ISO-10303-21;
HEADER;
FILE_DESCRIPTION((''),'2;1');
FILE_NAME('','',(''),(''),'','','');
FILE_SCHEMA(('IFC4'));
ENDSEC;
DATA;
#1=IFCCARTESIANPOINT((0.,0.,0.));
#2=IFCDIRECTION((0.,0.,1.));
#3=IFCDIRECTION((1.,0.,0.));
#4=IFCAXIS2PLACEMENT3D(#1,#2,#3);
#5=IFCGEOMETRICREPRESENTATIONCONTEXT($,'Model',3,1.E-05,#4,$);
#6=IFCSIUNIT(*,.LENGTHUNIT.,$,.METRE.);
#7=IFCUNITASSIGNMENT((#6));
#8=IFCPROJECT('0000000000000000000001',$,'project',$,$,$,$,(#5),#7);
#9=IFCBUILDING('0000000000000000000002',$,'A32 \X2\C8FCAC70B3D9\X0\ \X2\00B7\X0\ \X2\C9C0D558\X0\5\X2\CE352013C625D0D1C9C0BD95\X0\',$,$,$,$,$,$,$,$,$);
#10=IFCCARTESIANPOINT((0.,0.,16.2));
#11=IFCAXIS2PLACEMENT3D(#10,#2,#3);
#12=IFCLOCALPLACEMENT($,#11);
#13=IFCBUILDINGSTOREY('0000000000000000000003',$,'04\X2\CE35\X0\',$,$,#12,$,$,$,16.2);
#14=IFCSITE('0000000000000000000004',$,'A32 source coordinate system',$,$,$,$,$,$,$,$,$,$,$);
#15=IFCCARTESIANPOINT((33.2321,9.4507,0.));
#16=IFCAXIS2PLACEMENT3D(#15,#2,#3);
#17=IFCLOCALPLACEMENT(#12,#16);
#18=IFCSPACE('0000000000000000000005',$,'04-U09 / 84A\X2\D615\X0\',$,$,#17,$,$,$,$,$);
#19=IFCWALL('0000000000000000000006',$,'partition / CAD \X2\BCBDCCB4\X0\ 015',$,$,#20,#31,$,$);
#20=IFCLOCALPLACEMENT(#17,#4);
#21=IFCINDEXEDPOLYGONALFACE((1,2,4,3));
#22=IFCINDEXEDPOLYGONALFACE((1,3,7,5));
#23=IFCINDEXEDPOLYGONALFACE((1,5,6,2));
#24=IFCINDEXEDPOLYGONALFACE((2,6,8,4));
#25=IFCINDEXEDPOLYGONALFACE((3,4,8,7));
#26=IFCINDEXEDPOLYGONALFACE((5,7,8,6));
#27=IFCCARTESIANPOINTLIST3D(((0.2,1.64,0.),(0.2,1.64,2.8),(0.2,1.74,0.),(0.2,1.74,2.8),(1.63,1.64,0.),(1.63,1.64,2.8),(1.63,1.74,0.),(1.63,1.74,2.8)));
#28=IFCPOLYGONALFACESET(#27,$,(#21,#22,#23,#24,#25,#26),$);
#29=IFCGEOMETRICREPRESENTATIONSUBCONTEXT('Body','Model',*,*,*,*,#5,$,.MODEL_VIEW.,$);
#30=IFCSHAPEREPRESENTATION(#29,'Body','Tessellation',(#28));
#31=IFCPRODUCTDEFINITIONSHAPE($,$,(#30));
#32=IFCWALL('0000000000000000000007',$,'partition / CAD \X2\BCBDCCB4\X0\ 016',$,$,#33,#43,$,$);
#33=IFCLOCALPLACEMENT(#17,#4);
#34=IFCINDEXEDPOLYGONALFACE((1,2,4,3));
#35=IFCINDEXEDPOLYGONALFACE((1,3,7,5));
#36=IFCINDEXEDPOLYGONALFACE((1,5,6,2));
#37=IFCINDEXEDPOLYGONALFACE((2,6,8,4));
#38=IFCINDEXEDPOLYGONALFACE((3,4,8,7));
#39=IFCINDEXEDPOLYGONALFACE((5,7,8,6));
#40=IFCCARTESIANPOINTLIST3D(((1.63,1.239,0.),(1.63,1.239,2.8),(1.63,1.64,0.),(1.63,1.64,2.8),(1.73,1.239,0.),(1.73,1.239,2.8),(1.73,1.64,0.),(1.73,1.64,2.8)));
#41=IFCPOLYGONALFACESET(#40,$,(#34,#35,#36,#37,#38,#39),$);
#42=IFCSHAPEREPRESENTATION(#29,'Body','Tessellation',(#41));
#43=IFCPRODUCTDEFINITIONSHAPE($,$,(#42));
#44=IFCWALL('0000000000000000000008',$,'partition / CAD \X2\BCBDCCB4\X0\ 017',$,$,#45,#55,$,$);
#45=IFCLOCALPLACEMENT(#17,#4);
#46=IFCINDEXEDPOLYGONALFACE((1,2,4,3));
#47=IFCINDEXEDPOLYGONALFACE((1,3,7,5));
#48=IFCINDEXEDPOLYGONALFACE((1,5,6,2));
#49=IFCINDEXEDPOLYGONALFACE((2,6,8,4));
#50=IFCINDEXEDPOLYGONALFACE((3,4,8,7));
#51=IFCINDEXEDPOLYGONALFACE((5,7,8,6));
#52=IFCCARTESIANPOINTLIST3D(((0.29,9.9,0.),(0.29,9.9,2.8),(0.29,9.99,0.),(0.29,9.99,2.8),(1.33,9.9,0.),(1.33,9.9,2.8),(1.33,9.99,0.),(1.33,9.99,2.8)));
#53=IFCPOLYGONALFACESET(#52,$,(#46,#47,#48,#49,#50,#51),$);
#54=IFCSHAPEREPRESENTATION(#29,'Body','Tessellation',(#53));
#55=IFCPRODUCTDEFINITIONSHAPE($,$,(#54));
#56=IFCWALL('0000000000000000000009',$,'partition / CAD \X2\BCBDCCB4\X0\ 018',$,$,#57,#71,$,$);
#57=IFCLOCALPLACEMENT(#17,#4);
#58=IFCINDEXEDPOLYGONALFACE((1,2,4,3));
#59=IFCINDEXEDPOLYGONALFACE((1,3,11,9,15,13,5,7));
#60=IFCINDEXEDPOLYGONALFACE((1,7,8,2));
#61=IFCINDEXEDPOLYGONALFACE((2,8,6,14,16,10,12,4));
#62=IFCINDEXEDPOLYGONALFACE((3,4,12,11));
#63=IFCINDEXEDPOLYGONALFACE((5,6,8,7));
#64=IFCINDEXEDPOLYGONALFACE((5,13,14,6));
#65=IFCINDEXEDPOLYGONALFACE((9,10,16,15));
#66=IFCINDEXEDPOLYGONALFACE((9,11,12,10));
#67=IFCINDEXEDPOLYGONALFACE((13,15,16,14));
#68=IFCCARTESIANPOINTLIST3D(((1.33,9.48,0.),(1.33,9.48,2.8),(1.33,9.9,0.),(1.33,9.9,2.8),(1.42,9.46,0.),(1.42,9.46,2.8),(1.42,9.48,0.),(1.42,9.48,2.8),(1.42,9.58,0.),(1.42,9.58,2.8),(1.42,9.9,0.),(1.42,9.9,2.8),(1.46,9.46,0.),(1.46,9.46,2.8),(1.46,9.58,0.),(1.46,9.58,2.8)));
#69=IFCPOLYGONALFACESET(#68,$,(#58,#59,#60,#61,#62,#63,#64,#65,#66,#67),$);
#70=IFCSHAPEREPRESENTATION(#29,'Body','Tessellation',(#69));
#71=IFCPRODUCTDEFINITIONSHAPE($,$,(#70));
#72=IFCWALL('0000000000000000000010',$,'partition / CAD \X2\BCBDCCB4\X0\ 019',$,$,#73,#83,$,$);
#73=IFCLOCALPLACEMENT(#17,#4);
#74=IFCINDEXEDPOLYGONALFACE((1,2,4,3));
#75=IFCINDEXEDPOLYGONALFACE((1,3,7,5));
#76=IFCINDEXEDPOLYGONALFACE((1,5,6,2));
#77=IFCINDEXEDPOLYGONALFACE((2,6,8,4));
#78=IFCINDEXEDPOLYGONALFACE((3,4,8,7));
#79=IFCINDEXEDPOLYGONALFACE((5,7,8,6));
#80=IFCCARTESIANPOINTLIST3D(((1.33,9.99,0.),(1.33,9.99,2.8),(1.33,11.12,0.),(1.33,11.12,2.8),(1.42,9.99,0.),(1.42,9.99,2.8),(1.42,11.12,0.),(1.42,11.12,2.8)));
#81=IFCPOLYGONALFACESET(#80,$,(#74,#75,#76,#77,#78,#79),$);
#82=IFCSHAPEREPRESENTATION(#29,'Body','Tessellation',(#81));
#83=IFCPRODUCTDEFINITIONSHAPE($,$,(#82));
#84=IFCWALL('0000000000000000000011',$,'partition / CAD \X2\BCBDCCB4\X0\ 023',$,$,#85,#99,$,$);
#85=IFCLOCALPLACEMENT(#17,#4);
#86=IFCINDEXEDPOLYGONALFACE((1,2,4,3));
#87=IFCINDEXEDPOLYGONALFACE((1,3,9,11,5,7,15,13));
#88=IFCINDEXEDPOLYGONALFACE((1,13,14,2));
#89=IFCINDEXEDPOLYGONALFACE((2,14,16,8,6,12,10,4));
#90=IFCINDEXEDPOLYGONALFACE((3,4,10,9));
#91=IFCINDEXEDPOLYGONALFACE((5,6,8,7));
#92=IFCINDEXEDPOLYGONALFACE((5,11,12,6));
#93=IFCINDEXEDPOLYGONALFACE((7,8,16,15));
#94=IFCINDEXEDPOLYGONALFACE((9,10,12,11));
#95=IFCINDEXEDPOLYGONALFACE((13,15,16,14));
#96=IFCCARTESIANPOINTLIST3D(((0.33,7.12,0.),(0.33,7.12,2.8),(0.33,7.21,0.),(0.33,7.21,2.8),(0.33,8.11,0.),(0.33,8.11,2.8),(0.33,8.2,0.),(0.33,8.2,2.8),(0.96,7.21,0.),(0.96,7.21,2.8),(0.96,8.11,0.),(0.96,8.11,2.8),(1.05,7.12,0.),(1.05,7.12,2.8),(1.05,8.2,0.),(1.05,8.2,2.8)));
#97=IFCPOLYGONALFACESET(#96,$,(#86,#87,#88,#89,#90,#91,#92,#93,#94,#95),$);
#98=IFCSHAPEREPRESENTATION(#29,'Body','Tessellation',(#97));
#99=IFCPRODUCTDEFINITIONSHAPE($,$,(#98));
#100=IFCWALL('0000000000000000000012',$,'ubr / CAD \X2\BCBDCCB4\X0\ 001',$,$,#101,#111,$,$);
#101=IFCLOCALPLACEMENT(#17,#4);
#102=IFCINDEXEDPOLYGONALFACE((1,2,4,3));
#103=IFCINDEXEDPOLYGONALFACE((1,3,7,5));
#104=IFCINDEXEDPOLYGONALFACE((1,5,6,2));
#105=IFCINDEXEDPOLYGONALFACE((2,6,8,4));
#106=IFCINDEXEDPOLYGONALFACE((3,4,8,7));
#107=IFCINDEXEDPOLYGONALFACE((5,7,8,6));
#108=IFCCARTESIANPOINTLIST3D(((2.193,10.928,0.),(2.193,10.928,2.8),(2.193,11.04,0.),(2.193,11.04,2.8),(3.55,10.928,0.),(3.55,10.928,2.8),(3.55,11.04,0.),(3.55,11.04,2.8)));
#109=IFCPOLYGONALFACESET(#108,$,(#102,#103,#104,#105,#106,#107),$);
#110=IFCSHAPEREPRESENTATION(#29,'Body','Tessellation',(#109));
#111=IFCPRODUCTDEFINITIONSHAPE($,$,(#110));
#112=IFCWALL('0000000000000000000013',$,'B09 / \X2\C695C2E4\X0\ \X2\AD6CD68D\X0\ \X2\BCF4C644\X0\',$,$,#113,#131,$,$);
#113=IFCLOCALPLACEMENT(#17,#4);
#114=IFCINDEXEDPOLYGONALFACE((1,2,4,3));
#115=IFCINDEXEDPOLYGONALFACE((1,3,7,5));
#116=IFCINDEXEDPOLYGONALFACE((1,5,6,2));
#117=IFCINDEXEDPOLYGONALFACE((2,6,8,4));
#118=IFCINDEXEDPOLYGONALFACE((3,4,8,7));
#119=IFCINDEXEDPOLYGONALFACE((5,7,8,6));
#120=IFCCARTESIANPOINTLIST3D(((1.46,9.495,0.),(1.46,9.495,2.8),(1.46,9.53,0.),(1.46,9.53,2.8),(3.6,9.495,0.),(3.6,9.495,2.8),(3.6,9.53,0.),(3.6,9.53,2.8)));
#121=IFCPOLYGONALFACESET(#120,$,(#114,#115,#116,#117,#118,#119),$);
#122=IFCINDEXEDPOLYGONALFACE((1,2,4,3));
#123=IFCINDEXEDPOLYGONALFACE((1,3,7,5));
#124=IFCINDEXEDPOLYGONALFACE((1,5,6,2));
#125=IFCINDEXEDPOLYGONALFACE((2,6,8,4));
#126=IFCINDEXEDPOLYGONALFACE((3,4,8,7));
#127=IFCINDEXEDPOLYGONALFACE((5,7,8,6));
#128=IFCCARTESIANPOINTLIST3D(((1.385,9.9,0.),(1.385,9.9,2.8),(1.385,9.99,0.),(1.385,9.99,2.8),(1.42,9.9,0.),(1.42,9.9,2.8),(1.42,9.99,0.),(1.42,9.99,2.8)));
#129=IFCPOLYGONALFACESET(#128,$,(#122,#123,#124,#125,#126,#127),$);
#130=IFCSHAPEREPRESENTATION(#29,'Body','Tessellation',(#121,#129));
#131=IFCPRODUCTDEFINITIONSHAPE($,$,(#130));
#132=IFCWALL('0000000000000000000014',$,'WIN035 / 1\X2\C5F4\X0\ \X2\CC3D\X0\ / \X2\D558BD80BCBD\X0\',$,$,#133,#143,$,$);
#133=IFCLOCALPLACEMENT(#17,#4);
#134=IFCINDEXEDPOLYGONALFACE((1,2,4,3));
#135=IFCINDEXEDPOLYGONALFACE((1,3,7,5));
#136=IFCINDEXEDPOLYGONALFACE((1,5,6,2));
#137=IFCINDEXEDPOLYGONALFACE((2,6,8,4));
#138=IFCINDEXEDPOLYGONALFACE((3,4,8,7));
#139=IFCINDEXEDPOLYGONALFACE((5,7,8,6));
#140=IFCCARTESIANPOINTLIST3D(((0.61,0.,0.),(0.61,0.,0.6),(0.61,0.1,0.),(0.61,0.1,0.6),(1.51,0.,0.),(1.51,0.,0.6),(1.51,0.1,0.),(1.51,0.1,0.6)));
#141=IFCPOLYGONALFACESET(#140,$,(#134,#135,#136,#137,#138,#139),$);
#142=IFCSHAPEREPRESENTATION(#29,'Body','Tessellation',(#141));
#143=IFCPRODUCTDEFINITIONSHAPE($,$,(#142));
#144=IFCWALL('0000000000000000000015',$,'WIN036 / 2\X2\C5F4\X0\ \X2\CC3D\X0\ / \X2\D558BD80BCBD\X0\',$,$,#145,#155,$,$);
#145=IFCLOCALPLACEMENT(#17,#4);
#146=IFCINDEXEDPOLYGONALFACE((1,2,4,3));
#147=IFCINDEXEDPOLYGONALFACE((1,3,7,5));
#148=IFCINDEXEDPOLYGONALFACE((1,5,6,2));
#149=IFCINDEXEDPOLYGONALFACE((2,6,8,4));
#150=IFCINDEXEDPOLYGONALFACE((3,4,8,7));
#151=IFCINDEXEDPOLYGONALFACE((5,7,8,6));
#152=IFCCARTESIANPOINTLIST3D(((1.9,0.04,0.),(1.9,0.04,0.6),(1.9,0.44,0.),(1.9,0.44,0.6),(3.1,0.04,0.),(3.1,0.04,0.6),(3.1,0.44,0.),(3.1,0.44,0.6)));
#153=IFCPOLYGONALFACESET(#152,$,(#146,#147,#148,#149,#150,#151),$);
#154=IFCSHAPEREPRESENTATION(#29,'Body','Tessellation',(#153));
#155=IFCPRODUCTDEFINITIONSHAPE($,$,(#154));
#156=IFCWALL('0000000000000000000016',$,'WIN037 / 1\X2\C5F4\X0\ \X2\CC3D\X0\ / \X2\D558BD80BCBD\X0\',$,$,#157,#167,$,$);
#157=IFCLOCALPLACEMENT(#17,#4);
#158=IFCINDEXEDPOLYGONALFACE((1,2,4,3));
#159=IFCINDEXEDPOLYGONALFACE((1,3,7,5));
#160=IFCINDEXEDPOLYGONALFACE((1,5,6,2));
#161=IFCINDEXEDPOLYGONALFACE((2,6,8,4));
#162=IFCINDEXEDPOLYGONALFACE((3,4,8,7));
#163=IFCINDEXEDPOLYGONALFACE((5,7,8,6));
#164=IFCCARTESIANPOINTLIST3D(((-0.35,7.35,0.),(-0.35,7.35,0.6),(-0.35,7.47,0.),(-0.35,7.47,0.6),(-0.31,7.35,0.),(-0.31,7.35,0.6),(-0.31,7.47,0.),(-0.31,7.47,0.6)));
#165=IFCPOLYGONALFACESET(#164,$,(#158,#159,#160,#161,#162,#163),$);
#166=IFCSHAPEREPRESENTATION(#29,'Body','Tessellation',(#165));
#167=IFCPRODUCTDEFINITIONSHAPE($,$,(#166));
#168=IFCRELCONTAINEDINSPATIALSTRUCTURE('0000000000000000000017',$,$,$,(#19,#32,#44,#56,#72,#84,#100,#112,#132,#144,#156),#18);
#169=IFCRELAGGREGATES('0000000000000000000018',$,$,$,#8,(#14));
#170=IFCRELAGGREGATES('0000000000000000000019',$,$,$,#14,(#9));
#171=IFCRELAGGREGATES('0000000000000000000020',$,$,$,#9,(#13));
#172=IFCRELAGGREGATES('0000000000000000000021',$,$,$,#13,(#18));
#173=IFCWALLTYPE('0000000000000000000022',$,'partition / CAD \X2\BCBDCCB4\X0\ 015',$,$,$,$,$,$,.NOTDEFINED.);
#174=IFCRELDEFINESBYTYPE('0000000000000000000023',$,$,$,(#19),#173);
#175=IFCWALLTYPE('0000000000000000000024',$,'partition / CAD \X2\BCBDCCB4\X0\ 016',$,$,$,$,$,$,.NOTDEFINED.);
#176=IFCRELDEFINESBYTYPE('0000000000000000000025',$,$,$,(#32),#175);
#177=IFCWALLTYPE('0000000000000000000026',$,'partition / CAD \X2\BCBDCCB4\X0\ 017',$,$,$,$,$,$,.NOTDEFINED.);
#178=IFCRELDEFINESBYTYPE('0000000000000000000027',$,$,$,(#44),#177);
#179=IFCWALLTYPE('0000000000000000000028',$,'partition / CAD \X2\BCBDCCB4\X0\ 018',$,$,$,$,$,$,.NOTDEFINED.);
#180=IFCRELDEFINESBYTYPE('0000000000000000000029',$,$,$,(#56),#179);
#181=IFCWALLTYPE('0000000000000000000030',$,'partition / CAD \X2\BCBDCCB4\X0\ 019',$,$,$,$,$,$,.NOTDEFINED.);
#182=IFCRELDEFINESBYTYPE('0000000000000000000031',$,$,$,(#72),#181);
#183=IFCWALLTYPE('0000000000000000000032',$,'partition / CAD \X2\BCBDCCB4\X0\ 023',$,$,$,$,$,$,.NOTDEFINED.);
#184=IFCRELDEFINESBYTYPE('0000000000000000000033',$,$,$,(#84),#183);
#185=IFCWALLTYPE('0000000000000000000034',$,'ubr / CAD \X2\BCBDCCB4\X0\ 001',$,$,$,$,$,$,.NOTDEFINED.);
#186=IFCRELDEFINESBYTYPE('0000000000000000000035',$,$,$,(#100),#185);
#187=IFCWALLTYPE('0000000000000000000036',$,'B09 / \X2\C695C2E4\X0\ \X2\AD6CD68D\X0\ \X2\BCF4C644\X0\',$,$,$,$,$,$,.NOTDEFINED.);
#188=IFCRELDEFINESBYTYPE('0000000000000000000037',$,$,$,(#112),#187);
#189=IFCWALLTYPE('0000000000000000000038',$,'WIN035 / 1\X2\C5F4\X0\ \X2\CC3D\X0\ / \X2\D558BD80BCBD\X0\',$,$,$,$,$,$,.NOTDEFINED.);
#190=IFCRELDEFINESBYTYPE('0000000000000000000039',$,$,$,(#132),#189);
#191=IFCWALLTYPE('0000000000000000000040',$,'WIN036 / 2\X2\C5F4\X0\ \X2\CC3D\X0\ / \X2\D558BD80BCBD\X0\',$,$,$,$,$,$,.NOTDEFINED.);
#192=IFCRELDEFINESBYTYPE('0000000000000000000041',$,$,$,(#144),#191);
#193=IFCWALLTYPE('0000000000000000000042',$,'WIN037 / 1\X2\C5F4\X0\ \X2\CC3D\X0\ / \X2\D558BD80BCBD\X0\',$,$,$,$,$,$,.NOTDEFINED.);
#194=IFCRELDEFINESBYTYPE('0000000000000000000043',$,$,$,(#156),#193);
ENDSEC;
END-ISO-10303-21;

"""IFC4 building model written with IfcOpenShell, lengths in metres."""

from ifc_helpers import new_model, si_unit, frame, origin, origin_with_axes, place, context, subcontext, project, spatial, polyline, outline, extrude, source, transform, mapped, type_object, type_shapes, element, save


model = new_model("IFC4")

# Units and contexts
model_context = context("Model", 3, precision=1e-05, world=origin_with_axes())
body_context = subcontext(model_context, "Body", "Model", "MODEL_VIEW")
ifc_project = project(units=[si_unit("LENGTHUNIT", "METRE")], contexts=[model_context])

# Site, building, storey, space
site = spatial("IfcSite", under=ifc_project, Name="A32 source coordinate system")
building = spatial("IfcBuilding", under=site, Name="A32 주거동 · 지하5층–옥탑지붕")
storey_placement = place(None, frame((0.0, 0.0, 16.2), z_axis=(0.0, 0.0, 1.0), x_axis=(1.0, 0.0, 0.0)))
storey = spatial("IfcBuildingStorey", under=building, at=storey_placement, Name="04층", Elevation=16.2)
space_1_placement = place(storey_placement, frame((33.2321, 9.4507, 0.0), z_axis=(0.0, 0.0, 1.0), x_axis=(1.0, 0.0, 0.0)))
space_1 = spatial("IfcSpace", under=storey, at=space_1_placement, Name="04-U09 / 84A형")

# Walls
wall_type_1 = type_object("IfcWallType", Name="partition / CAD 벽체 015", PredefinedType="NOTDEFINED")
shared_shape_1 = source(origin(), body_context, "Body", "SweptSolid", [
    extrude(outline(polyline([(1.63, 1.74), (1.63, 1.64), (0.2, 1.64), (0.2, 1.74), (1.63, 1.74)])), origin(), (0.0, 0.0, 1.0), 2.8),
])
type_shapes(wall_type_1, [shared_shape_1])
wall_1_placement = place(space_1_placement, origin_with_axes())
element("IfcWall", 1, at=wall_1_placement, inside=space_1, type_object=wall_type_1, Name="partition / CAD 벽체 015", context=body_context, shape_type="MappedRepresentation", body=[
    mapped(shared_shape_1, transform((0.0, 0.0, 0.0), scale=1.0)),
])
wall_type_2 = type_object("IfcWallType", Name="partition / CAD 벽체 016", PredefinedType="NOTDEFINED")
shared_shape_2 = source(origin(), body_context, "Body", "SweptSolid", [
    extrude(outline(polyline([(1.73, 1.239), (1.63, 1.239), (1.63, 1.64), (1.73, 1.64), (1.73, 1.239)])), origin(), (0.0, 0.0, 1.0), 2.8),
])
type_shapes(wall_type_2, [shared_shape_2])
wall_2_placement = place(space_1_placement, origin_with_axes())
element("IfcWall", 2, at=wall_2_placement, inside=space_1, type_object=wall_type_2, Name="partition / CAD 벽체 016", context=body_context, shape_type="MappedRepresentation", body=[
    mapped(shared_shape_2, transform((0.0, 0.0, 0.0), scale=1.0)),
])
wall_type_3 = type_object("IfcWallType", Name="partition / CAD 벽체 017", PredefinedType="NOTDEFINED")
shared_shape_3 = source(origin(), body_context, "Body", "SweptSolid", [
    extrude(outline(polyline([(1.33, 9.99), (1.33, 9.9), (0.29, 9.9), (0.29, 9.99), (1.33, 9.99)])), origin(), (0.0, 0.0, 1.0), 2.8),
])
type_shapes(wall_type_3, [shared_shape_3])
wall_3_placement = place(space_1_placement, origin_with_axes())
element("IfcWall", 3, at=wall_3_placement, inside=space_1, type_object=wall_type_3, Name="partition / CAD 벽체 017", context=body_context, shape_type="MappedRepresentation", body=[
    mapped(shared_shape_3, transform((0.0, 0.0, 0.0), scale=1.0)),
])
wall_type_4 = type_object("IfcWallType", Name="partition / CAD 벽체 018", PredefinedType="NOTDEFINED")
shared_shape_4 = source(origin(), body_context, "Body", "SweptSolid", [
    extrude(outline(polyline([(1.42, 9.58), (1.46, 9.58), (1.46, 9.46), (1.42, 9.46), (1.42, 9.48), (1.33, 9.48), (1.33, 9.9), (1.42, 9.9), (1.42, 9.58)])), origin(), (0.0, 0.0, 1.0), 2.8),
])
type_shapes(wall_type_4, [shared_shape_4])
wall_4_placement = place(space_1_placement, origin_with_axes())
element("IfcWall", 4, at=wall_4_placement, inside=space_1, type_object=wall_type_4, Name="partition / CAD 벽체 018", context=body_context, shape_type="MappedRepresentation", body=[
    mapped(shared_shape_4, transform((0.0, 0.0, 0.0), scale=1.0)),
])
wall_type_5 = type_object("IfcWallType", Name="partition / CAD 벽체 019", PredefinedType="NOTDEFINED")
shared_shape_5 = source(origin(), body_context, "Body", "SweptSolid", [
    extrude(outline(polyline([(1.33, 11.12), (1.42, 11.12), (1.42, 9.99), (1.33, 9.99), (1.33, 11.12)])), origin(), (0.0, 0.0, 1.0), 2.8),
])
type_shapes(wall_type_5, [shared_shape_5])
wall_5_placement = place(space_1_placement, origin_with_axes())
element("IfcWall", 5, at=wall_5_placement, inside=space_1, type_object=wall_type_5, Name="partition / CAD 벽체 019", context=body_context, shape_type="MappedRepresentation", body=[
    mapped(shared_shape_5, transform((0.0, 0.0, 0.0), scale=1.0)),
])
wall_type_6 = type_object("IfcWallType", Name="partition / CAD 벽체 023", PredefinedType="NOTDEFINED")
shared_shape_6 = source(origin(), body_context, "Body", "SweptSolid", [
    extrude(outline(polyline([(0.96, 8.11), (0.33, 8.11), (0.33, 8.2), (1.05, 8.2), (1.05, 7.12), (0.33, 7.12), (0.33, 7.21), (0.96, 7.21), (0.96, 8.11)])), origin(), (0.0, 0.0, 1.0), 2.8),
])
type_shapes(wall_type_6, [shared_shape_6])
wall_6_placement = place(space_1_placement, origin_with_axes())
element("IfcWall", 6, at=wall_6_placement, inside=space_1, type_object=wall_type_6, Name="partition / CAD 벽체 023", context=body_context, shape_type="MappedRepresentation", body=[
    mapped(shared_shape_6, transform((0.0, 0.0, 0.0), scale=1.0)),
])
wall_type_7 = type_object("IfcWallType", Name="ubr / CAD 벽체 001", PredefinedType="NOTDEFINED")
shared_shape_7 = source(origin(), body_context, "Body", "SweptSolid", [
    extrude(outline(polyline([(3.55, 11.04), (3.55, 10.928), (2.193, 10.928), (2.193, 11.04), (3.55, 11.04)])), origin(), (0.0, 0.0, 1.0), 2.8),
])
type_shapes(wall_type_7, [shared_shape_7])
wall_7_placement = place(space_1_placement, origin_with_axes())
element("IfcWall", 7, at=wall_7_placement, inside=space_1, type_object=wall_type_7, Name="ubr / CAD 벽체 001", context=body_context, shape_type="MappedRepresentation", body=[
    mapped(shared_shape_7, transform((0.0, 0.0, 0.0), scale=1.0)),
])
wall_type_8 = type_object("IfcWallType", Name="B09 / 욕실 구획 보완", PredefinedType="NOTDEFINED")
shared_shape_8 = source(origin(), body_context, "Body", "SweptSolid", [
    extrude(outline(polyline([(3.6, 9.53), (3.6, 9.495), (1.46, 9.495), (1.46, 9.53), (3.6, 9.53)])), origin(), (0.0, 0.0, 1.0), 2.8),
    extrude(outline(polyline([(1.42, 9.9), (1.385, 9.9), (1.385, 9.99), (1.42, 9.99), (1.42, 9.9)])), origin(), (0.0, 0.0, 1.0), 2.8),
])
type_shapes(wall_type_8, [shared_shape_8])
wall_8_placement = place(space_1_placement, origin_with_axes())
element("IfcWall", 8, at=wall_8_placement, inside=space_1, type_object=wall_type_8, Name="B09 / 욕실 구획 보완", context=body_context, shape_type="MappedRepresentation", body=[
    mapped(shared_shape_8, transform((0.0, 0.0, 0.0), scale=1.0)),
])
wall_type_9 = type_object("IfcWallType", Name="WIN035 / 1열 창 / 하부벽", PredefinedType="NOTDEFINED")
shared_shape_9 = source(origin(), body_context, "Body", "SweptSolid", [
    extrude(outline(polyline([(0.61, 0.1), (1.51, 0.1), (1.51, 0.0), (0.61, 0.0), (0.61, 0.1)])), origin(), (0.0, 0.0, 1.0), 0.6),
])
type_shapes(wall_type_9, [shared_shape_9])
wall_9_placement = place(space_1_placement, origin_with_axes())
element("IfcWall", 9, at=wall_9_placement, inside=space_1, type_object=wall_type_9, Name="WIN035 / 1열 창 / 하부벽", context=body_context, shape_type="MappedRepresentation", body=[
    mapped(shared_shape_9, transform((0.0, 0.0, 0.0), scale=1.0)),
])
wall_type_10 = type_object("IfcWallType", Name="WIN036 / 2열 창 / 하부벽", PredefinedType="NOTDEFINED")
shared_shape_10 = source(origin(), body_context, "Body", "SweptSolid", [
    extrude(outline(polyline([(1.9, 0.44), (3.1, 0.44), (3.1, 0.04), (1.9, 0.04), (1.9, 0.44)])), origin(), (0.0, 0.0, 1.0), 0.6),
])
type_shapes(wall_type_10, [shared_shape_10])
wall_10_placement = place(space_1_placement, origin_with_axes())
element("IfcWall", 10, at=wall_10_placement, inside=space_1, type_object=wall_type_10, Name="WIN036 / 2열 창 / 하부벽", context=body_context, shape_type="MappedRepresentation", body=[
    mapped(shared_shape_10, transform((0.0, 0.0, 0.0), scale=1.0)),
])
wall_type_11 = type_object("IfcWallType", Name="WIN037 / 1열 창 / 하부벽", PredefinedType="NOTDEFINED")
shared_shape_11 = source(origin(), body_context, "Body", "SweptSolid", [
    extrude(outline(polyline([(-0.31, 7.47), (-0.31, 7.35), (-0.35, 7.35), (-0.35, 7.47), (-0.31, 7.47)])), origin(), (0.0, 0.0, 1.0), 0.6),
])
type_shapes(wall_type_11, [shared_shape_11])
wall_11_placement = place(space_1_placement, origin_with_axes())
element("IfcWall", 11, at=wall_11_placement, inside=space_1, type_object=wall_type_11, Name="WIN037 / 1열 창 / 하부벽", context=body_context, shape_type="MappedRepresentation", body=[
    mapped(shared_shape_11, transform((0.0, 0.0, 0.0), scale=1.0)),
])

save(model, "model.ifc")
